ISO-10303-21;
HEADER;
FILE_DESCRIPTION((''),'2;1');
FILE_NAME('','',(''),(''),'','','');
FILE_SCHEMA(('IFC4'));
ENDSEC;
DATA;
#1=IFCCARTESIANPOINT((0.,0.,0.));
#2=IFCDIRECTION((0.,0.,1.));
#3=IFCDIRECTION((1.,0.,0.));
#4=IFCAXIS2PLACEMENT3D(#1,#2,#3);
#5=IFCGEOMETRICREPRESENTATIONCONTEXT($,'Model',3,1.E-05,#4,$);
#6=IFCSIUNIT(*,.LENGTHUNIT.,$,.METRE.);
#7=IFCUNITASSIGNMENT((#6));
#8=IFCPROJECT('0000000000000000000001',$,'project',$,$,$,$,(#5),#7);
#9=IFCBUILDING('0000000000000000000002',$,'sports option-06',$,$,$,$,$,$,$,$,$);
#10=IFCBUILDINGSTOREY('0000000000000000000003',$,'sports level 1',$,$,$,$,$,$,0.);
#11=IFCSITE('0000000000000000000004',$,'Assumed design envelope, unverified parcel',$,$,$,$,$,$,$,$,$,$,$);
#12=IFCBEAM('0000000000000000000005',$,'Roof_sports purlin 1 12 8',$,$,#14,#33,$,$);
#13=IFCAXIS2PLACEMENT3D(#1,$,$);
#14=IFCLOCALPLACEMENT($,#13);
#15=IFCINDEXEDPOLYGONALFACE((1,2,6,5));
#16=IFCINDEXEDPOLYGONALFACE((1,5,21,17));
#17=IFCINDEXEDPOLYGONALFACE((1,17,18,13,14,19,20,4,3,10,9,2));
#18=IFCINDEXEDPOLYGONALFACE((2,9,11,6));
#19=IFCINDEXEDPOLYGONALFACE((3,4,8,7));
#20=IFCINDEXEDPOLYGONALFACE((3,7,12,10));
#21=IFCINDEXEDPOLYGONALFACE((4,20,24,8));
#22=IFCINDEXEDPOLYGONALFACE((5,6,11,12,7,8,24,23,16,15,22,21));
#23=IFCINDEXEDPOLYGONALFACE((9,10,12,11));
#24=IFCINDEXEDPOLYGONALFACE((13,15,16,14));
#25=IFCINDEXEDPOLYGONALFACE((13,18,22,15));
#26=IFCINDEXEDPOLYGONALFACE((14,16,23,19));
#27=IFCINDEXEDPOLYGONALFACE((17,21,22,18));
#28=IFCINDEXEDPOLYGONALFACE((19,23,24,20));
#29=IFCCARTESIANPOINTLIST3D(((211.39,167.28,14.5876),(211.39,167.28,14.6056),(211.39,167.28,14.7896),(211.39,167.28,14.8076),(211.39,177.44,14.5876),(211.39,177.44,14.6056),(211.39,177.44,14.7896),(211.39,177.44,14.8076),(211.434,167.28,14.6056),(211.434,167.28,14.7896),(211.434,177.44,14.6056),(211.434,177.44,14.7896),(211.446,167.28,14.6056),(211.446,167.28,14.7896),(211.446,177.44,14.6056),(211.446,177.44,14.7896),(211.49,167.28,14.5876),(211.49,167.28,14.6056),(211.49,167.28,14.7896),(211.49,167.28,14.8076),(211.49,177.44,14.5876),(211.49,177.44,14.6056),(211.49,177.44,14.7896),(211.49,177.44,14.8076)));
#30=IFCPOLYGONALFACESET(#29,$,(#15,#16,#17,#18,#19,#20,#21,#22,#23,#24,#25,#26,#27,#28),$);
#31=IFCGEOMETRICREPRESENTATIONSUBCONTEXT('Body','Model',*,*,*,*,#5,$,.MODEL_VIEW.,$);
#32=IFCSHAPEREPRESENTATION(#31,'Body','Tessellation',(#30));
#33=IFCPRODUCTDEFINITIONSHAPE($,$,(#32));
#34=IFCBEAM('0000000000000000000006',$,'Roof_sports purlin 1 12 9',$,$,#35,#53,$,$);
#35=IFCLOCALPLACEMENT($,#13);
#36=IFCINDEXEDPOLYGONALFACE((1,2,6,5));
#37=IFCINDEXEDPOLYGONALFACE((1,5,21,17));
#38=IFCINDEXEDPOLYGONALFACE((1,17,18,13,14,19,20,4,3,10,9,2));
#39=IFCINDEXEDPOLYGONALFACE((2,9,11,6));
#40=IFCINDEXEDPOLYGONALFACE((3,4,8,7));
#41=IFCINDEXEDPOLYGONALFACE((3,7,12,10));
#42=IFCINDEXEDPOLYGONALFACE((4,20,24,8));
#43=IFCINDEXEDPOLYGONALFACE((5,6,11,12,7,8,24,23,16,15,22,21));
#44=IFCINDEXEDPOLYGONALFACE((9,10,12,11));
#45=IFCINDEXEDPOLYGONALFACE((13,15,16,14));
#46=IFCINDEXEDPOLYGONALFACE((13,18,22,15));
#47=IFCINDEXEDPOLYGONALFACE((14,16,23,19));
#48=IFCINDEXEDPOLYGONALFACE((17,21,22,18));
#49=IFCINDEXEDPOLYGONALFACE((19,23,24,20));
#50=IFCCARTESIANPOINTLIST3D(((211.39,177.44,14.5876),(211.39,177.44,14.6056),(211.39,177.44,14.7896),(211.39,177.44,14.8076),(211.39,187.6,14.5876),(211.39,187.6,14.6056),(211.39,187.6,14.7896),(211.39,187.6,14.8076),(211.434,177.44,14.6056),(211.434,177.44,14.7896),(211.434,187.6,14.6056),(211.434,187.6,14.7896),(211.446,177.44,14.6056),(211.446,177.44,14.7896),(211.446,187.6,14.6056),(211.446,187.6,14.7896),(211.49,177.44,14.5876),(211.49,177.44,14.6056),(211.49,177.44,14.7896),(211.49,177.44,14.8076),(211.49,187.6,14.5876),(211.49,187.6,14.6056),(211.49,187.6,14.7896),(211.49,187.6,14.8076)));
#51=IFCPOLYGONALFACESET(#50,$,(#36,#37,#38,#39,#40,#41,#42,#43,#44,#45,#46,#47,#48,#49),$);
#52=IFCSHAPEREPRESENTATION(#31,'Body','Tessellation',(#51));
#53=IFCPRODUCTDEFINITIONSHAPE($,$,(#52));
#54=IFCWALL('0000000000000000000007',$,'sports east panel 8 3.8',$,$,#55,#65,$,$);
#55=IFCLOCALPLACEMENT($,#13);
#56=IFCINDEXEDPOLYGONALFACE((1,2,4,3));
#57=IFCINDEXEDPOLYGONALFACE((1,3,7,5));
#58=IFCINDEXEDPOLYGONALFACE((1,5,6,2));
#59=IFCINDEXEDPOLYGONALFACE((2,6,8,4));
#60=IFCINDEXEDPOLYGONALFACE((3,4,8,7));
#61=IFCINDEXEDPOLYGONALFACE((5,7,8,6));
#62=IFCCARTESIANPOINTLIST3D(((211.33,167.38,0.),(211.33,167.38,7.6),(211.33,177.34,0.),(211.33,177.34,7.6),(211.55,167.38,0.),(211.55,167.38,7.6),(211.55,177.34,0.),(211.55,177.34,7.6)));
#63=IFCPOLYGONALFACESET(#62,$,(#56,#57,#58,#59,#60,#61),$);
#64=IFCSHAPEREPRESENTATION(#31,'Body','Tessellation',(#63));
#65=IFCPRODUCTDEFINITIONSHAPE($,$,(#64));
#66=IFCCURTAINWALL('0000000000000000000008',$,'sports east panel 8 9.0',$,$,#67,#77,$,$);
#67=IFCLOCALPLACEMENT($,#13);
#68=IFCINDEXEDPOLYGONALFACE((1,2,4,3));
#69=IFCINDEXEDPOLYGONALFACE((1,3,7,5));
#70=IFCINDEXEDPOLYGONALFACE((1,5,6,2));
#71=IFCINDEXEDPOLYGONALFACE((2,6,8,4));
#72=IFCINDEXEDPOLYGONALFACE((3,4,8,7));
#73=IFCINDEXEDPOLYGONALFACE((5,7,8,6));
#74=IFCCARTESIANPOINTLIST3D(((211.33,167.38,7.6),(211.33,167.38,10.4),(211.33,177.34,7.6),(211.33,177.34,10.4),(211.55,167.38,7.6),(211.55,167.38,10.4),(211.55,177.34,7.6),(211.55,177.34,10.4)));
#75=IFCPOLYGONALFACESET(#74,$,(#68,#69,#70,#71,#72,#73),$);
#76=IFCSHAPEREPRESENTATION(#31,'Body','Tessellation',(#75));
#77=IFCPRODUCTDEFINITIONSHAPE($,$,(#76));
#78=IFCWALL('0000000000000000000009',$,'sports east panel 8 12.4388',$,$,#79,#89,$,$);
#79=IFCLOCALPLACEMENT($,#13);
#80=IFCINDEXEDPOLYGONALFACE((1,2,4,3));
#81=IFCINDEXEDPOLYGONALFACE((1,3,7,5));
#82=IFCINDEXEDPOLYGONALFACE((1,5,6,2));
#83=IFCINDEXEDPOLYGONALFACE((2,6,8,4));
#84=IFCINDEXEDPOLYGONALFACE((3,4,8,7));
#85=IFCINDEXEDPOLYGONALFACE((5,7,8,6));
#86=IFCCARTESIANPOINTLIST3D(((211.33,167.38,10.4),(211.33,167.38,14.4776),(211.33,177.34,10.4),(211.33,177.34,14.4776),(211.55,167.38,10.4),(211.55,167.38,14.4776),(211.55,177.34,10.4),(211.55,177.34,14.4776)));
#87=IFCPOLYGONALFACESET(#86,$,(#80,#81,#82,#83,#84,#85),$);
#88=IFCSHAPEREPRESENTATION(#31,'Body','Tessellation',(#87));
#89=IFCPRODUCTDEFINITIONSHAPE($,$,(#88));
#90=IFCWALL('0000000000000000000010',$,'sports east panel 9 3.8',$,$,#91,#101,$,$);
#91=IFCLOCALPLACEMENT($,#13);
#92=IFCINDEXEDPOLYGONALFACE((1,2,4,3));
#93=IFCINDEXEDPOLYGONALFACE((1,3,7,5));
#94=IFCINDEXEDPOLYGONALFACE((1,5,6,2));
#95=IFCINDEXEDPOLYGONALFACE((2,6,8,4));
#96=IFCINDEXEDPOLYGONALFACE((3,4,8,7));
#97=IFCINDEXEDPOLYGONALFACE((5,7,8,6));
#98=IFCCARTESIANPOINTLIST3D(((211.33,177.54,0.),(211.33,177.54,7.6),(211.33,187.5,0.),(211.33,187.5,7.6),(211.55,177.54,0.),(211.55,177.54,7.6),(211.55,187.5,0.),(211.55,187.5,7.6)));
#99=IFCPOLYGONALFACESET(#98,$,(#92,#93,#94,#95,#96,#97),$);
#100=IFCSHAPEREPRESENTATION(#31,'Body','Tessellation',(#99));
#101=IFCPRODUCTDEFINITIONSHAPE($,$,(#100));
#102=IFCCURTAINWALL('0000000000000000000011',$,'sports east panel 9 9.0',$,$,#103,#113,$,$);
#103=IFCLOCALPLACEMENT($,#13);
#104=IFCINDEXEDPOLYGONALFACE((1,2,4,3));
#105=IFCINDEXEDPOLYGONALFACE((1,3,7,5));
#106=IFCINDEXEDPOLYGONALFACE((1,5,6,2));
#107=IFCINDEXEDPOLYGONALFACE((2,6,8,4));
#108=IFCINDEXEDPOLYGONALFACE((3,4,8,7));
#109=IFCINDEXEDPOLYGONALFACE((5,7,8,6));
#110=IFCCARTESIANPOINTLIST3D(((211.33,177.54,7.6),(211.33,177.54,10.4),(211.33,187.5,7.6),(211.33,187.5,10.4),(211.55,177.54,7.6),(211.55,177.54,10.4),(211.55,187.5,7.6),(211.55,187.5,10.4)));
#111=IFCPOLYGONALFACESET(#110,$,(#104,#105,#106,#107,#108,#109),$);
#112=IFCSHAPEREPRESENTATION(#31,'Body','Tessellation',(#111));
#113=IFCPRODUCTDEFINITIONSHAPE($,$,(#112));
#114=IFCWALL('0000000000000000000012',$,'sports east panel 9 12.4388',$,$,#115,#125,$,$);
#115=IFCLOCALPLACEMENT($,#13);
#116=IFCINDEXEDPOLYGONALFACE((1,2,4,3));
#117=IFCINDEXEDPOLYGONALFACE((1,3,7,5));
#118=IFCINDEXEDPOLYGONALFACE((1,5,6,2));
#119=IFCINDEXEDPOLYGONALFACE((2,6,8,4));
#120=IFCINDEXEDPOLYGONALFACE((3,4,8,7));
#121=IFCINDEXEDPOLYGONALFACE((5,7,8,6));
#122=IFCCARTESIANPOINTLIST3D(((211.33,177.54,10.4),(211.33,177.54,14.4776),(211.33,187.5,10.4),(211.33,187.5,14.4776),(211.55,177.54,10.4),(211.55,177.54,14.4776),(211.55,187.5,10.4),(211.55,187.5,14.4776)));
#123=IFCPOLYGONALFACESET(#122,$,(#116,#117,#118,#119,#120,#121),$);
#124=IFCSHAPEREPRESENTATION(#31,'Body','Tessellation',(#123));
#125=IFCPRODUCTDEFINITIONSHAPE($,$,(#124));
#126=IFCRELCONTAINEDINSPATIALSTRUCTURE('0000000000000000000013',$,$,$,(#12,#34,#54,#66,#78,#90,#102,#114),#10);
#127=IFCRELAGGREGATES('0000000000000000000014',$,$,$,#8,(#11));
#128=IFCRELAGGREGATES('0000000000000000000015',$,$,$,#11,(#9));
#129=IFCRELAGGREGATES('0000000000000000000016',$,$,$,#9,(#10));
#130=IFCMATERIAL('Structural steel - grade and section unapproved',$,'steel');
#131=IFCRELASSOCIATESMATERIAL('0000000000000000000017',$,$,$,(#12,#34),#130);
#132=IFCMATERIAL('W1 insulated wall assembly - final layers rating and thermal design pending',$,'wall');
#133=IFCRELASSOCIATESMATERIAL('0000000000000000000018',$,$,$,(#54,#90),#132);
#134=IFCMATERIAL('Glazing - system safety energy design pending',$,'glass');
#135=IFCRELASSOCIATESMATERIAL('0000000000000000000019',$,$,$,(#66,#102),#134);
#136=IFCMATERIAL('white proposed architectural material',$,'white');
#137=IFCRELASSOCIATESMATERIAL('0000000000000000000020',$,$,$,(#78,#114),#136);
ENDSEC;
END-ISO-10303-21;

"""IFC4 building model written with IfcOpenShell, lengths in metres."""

from ifc_helpers import new_model, si_unit, frame, origin_with_axes, place, context, subcontext, project, spatial, rectangle, i_section, extrude, material, element, save


model = new_model("IFC4")

# Units and contexts
model_context = context("Model", 3, precision=1e-05, world=origin_with_axes())
body_context = subcontext(model_context, "Body", "Model", "MODEL_VIEW")
ifc_project = project(units=[si_unit("LENGTHUNIT", "METRE")], contexts=[model_context])

# Site, building, storey
site = spatial("IfcSite", under=ifc_project, Name="Assumed design envelope, unverified parcel")
building = spatial("IfcBuilding", under=site, Name="sports option-06")
storey = spatial("IfcBuildingStorey", under=building, Name="sports level 1", Elevation=0.0)

# Shared definitions
ifc_material_1 = material(Name="Structural steel - grade and section unapproved", Category="steel")

# Beams
for number, where, z_axis, x_axis, name in (
    (1, (211.44, 167.28, 14.6976), (0.0, 1.0, 0.0), (-1.0, 0.0, 0.0), "Roof_sports purlin 1 12 8"),
    (2, (211.44, 177.44, 14.6976), (0.0, 1.0, 0.0), (-1.0, 0.0, 0.0), "Roof_sports purlin 1 12 9"),
):
    element("IfcBeam", number, at=place(None, frame(where, z_axis=z_axis, x_axis=x_axis)), inside=storey, material=ifc_material_1, Name=name, context=body_context, shape_type="SweptSolid", body=[
        extrude(i_section(OverallWidth=0.1, OverallDepth=0.22, WebThickness=0.012, FlangeThickness=0.018, FilletRadius=0.0), origin_with_axes(), (0.0, 0.0, 1.0), 10.16),
    ])

# Wall
ifc_material_2 = material(Name="W1 insulated wall assembly - final layers rating and thermal design pending", Category="wall")
wall_1_placement = place(None, frame((211.44, 172.36, 0.0), z_axis=(0.0, 0.0, 1.0), x_axis=(1.0, 0.0, 0.0)))
element("IfcWall", 3, at=wall_1_placement, inside=storey, material=ifc_material_2, Name="sports east panel 8 3.8", context=body_context, shape_type="SweptSolid", body=[
    extrude(rectangle(XDim=0.22, YDim=9.96), origin_with_axes(), (0.0, 0.0, 1.0), 7.6),
])

# Curtain wall
ifc_material_3 = material(Name="Glazing - system safety energy design pending", Category="glass")
curtain_wall_1_placement = place(None, frame((211.44, 172.36, 7.6), z_axis=(0.0, 0.0, 1.0), x_axis=(1.0, 0.0, 0.0)))
element("IfcCurtainWall", 4, at=curtain_wall_1_placement, inside=storey, material=ifc_material_3, Name="sports east panel 8 9.0", context=body_context, shape_type="SweptSolid", body=[
    extrude(rectangle(XDim=0.22, YDim=9.96), origin_with_axes(), (0.0, 0.0, 1.0), 2.8),
])

# Walls
ifc_material_4 = material(Name="white proposed architectural material", Category="white")
wall_2_placement = place(None, frame((211.44, 172.36, 10.4), z_axis=(0.0, 0.0, 1.0), x_axis=(1.0, 0.0, 0.0)))
element("IfcWall", 5, at=wall_2_placement, inside=storey, material=ifc_material_4, Name="sports east panel 8 12.4388", context=body_context, shape_type="SweptSolid", body=[
    extrude(rectangle(XDim=0.22, YDim=9.96), origin_with_axes(), (0.0, 0.0, 1.0), 4.0776),
])
wall_3_placement = place(None, frame((211.44, 182.52, 0.0), z_axis=(0.0, 0.0, 1.0), x_axis=(1.0, 0.0, 0.0)))
element("IfcWall", 6, at=wall_3_placement, inside=storey, material=ifc_material_2, Name="sports east panel 9 3.8", context=body_context, shape_type="SweptSolid", body=[
    extrude(rectangle(XDim=0.22, YDim=9.96), origin_with_axes(), (0.0, 0.0, 1.0), 7.6),
])

# Curtain wall
curtain_wall_2_placement = place(None, frame((211.44, 182.52, 7.6), z_axis=(0.0, 0.0, 1.0), x_axis=(1.0, 0.0, 0.0)))
element("IfcCurtainWall", 7, at=curtain_wall_2_placement, inside=storey, material=ifc_material_3, Name="sports east panel 9 9.0", context=body_context, shape_type="SweptSolid", body=[
    extrude(rectangle(XDim=0.22, YDim=9.96), origin_with_axes(), (0.0, 0.0, 1.0), 2.8),
])

# Wall
wall_4_placement = place(None, frame((211.44, 182.52, 10.4), z_axis=(0.0, 0.0, 1.0), x_axis=(1.0, 0.0, 0.0)))
element("IfcWall", 8, at=wall_4_placement, inside=storey, material=ifc_material_4, Name="sports east panel 9 12.4388", context=body_context, shape_type="SweptSolid", body=[
    extrude(rectangle(XDim=0.22, YDim=9.96), origin_with_axes(), (0.0, 0.0, 1.0), 4.0776),
])

save(model, "model.ifc")
